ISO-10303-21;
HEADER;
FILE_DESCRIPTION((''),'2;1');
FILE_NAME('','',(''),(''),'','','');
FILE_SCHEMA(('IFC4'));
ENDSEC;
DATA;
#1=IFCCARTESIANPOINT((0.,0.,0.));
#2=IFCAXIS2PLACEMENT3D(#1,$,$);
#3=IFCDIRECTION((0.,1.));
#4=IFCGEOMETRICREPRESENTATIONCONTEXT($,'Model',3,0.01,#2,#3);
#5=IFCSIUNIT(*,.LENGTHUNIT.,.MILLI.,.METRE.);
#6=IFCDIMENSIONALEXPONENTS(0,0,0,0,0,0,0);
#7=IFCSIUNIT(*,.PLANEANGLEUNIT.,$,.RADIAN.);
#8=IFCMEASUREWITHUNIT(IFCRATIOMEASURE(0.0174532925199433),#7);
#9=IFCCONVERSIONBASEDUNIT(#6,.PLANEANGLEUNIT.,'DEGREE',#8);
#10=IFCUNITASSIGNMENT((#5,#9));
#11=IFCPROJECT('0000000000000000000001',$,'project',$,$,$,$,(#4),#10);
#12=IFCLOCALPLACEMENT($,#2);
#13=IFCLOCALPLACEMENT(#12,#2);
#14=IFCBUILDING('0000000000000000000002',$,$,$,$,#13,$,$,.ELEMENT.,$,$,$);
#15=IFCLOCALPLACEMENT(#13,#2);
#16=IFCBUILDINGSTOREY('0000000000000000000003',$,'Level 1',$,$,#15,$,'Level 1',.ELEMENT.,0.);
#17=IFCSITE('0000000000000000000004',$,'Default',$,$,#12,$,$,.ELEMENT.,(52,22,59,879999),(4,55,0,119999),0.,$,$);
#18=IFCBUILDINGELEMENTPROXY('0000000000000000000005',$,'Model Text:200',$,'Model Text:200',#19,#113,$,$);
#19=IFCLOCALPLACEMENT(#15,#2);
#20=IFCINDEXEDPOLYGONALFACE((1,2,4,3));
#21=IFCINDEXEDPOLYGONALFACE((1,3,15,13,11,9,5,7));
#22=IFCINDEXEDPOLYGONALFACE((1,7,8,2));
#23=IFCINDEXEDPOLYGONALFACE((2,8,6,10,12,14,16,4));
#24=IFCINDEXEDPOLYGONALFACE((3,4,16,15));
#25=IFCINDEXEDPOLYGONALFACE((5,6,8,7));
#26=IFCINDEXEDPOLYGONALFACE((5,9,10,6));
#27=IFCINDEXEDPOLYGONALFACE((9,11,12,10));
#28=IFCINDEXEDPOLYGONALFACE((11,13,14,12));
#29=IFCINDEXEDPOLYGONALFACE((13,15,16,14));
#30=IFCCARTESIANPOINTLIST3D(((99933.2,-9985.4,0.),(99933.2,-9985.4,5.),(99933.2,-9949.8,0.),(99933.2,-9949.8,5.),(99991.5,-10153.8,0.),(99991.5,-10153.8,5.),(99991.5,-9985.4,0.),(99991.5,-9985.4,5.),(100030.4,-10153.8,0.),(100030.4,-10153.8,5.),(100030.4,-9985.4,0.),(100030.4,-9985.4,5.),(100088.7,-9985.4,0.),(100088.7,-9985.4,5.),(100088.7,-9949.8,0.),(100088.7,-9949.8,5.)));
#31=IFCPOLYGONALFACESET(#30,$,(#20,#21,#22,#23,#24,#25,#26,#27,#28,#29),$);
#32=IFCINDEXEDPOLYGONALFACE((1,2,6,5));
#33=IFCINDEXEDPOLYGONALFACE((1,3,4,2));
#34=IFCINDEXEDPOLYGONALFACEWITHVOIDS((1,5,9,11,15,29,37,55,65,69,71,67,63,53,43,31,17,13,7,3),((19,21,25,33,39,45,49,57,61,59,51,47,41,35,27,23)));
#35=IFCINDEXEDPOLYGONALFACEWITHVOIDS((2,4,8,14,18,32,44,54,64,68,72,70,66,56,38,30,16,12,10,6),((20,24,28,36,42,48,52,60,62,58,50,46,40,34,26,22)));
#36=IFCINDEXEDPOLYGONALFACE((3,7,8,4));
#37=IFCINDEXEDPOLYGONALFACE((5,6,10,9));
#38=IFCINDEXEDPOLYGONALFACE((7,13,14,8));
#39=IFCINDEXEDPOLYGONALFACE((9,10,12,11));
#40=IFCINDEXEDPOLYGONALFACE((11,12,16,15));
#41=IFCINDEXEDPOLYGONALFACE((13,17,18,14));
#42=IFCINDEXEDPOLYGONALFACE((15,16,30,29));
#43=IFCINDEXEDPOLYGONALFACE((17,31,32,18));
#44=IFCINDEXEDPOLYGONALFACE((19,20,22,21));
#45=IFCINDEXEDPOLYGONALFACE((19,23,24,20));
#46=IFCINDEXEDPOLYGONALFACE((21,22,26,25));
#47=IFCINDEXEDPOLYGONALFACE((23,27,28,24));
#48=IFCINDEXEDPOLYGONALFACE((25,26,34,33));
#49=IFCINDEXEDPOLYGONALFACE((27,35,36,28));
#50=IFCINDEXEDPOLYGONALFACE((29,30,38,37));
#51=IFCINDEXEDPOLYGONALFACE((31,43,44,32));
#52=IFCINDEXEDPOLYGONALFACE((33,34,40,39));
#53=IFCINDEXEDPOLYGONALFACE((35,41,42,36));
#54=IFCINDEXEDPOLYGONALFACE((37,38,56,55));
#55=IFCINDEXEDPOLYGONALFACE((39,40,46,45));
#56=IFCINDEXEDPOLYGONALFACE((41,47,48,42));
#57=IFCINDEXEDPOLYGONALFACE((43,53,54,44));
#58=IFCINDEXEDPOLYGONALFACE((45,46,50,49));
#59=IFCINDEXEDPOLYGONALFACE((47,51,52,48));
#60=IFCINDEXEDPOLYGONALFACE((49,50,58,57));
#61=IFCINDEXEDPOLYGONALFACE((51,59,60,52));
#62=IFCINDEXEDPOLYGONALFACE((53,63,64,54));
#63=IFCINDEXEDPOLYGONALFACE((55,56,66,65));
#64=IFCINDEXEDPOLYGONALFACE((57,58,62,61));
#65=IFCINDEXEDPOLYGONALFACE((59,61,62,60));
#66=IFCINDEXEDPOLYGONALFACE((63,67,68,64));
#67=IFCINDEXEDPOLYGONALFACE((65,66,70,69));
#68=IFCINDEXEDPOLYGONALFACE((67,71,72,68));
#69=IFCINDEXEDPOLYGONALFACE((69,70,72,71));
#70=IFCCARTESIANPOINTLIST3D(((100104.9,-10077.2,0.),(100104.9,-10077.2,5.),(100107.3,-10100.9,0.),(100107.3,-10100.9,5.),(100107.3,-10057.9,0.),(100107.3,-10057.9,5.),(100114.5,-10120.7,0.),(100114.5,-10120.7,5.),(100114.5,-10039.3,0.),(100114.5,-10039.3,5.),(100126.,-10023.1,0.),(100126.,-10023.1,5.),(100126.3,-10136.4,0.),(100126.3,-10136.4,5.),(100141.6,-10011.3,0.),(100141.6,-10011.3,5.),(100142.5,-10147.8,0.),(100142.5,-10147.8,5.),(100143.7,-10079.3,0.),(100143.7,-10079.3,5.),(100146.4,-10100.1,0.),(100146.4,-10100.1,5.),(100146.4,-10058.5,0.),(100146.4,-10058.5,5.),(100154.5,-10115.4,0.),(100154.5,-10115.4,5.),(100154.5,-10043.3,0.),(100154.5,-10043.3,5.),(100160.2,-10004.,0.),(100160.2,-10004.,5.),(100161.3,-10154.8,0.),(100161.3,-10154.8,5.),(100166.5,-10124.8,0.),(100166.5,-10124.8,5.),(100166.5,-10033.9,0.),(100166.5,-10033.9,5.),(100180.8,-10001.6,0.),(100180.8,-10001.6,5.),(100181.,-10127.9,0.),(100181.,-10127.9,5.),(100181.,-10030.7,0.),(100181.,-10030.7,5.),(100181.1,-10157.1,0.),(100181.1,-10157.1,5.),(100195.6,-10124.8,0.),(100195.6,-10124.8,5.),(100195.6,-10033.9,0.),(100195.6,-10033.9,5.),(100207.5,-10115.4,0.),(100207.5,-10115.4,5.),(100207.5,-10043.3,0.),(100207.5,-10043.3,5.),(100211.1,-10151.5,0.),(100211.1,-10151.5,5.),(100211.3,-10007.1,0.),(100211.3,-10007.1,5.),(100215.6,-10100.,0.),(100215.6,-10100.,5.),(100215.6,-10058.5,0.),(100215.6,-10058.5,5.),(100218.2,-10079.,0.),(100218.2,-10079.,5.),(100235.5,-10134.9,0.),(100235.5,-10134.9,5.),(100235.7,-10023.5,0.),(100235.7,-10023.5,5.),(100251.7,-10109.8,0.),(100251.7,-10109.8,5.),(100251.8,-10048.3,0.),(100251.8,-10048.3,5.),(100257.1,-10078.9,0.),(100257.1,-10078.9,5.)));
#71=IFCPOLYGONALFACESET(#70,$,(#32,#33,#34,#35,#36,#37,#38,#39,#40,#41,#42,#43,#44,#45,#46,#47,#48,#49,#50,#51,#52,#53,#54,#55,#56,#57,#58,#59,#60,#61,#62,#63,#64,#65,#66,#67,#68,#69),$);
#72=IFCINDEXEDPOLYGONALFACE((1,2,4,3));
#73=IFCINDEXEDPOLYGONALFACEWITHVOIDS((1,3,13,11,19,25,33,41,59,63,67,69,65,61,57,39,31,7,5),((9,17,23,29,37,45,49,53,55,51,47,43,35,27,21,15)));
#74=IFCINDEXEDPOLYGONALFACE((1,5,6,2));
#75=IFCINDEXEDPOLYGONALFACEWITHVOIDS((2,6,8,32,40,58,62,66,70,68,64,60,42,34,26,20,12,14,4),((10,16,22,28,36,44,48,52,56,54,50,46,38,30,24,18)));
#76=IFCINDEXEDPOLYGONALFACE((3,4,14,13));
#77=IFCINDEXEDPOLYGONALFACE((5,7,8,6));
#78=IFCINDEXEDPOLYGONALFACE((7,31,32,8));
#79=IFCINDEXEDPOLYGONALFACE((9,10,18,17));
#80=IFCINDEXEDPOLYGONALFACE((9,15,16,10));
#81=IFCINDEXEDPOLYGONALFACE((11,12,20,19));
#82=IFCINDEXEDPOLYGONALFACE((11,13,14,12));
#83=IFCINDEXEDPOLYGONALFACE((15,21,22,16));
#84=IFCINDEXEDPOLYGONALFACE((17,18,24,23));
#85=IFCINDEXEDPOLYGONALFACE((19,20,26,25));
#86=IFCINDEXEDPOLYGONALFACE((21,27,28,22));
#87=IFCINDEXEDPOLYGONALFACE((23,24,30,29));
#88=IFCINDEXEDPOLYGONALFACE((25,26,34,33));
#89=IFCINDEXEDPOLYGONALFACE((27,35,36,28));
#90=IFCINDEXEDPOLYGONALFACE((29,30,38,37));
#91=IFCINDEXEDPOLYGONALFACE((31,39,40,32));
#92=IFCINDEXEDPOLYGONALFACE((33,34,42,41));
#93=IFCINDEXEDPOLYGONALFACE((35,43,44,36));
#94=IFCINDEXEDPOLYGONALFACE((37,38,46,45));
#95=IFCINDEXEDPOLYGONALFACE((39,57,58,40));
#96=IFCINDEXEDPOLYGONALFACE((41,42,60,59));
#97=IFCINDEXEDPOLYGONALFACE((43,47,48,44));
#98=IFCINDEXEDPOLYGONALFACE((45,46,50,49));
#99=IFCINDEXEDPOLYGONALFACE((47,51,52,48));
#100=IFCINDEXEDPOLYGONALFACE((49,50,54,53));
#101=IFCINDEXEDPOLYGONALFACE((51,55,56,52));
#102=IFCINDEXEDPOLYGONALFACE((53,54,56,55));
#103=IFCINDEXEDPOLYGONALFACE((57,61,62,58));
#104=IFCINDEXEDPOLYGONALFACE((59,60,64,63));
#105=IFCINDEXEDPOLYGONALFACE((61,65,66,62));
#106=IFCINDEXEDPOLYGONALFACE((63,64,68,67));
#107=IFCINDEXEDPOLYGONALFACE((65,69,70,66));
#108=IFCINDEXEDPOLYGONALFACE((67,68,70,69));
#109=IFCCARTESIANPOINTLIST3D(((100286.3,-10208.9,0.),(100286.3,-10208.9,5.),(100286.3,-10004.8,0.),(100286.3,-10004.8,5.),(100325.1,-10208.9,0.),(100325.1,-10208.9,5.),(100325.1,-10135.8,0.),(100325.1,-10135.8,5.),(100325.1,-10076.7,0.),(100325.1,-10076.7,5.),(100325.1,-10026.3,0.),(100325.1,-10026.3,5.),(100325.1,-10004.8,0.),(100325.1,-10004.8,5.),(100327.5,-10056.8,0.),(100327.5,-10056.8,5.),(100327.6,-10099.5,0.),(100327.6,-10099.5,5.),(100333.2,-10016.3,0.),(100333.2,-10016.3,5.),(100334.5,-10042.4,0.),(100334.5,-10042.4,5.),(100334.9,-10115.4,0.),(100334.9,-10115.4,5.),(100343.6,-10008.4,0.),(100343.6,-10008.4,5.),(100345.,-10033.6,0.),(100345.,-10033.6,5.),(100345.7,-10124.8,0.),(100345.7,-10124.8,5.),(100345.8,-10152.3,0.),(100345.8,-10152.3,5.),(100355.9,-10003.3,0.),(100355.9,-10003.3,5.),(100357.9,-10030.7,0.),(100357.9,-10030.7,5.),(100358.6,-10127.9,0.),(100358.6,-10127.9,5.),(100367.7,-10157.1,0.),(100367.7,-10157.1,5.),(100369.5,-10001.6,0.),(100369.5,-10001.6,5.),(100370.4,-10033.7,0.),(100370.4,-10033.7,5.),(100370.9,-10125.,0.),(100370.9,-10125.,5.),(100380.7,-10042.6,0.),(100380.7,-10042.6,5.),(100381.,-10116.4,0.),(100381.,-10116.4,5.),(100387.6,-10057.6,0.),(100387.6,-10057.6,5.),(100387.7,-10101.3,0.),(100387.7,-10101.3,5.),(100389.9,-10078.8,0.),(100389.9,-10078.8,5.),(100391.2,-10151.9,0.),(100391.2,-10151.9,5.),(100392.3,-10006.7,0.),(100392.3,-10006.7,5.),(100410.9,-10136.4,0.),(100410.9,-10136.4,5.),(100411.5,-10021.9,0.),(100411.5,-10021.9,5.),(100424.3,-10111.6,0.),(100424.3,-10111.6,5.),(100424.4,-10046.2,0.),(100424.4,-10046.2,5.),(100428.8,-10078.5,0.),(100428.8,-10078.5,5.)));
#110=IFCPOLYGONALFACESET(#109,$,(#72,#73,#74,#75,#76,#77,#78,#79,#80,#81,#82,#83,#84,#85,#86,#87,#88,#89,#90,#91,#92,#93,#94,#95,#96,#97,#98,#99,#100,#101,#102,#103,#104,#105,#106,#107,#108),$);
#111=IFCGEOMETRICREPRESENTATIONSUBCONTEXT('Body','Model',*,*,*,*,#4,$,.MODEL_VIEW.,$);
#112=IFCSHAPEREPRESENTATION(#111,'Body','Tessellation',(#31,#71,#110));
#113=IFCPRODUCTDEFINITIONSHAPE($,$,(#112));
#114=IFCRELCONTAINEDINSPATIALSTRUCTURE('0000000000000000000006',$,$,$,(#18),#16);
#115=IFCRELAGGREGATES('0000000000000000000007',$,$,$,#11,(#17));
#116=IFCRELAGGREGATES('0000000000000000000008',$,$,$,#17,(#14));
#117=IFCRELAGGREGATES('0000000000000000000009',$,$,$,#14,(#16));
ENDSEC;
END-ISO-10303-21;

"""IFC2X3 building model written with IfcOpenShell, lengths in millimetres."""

from ifc_helpers import new_model, entity, si_unit, converted_unit, direction, frame, origin, place, context, subcontext, project, spatial, polyline, outline, extrude, element, save


model = new_model("IFC2X3")

# Units and contexts
model_context = context("Model", 3, precision=0.01, world=origin(), true_north=direction((0.0, 1.0)))
body_context = subcontext(model_context, "Body", "Model", "MODEL_VIEW")
ifc_project = project(units=[si_unit("LENGTHUNIT", "METRE", prefix="MILLI"), converted_unit("PLANEANGLEUNIT", "DEGREE", entity("IfcRatioMeasure", 0.0174532925199433), si_unit("PLANEANGLEUNIT", "RADIAN"), dimensions=[0, 0, 0, 0, 0, 0, 0])], contexts=[model_context])

# Site, building, storey
site_placement = place(None, origin())
site = spatial("IfcSite", under=ifc_project, at=site_placement, Name="Default", CompositionType="ELEMENT", RefLatitude=(52, 22, 59, 879999), RefLongitude=(4, 55, 0, 119999), RefElevation=0.0)
building_placement = place(site_placement, origin())
building = spatial("IfcBuilding", under=site, at=building_placement, CompositionType="ELEMENT")
storey_placement = place(building_placement, origin())
storey = spatial("IfcBuildingStorey", under=building, at=storey_placement, Name="Level 1", LongName="Level 1", CompositionType="ELEMENT", Elevation=0.0)

# Building element proxy
proxy_1_placement = place(building_placement, origin())
element("IfcBuildingElementProxy", 1, at=proxy_1_placement, inside=storey, Name="Model Text:200", ObjectType="Model Text:200", context=body_context, shape_type="SweptSolid", body=[
    extrude(outline(polyline([(-19.4, -135.2), (19.4, -135.2), (19.4, 33.2), (77.7, 33.2), (77.7, 68.8), (-77.7, 68.8), (-77.7, 33.2), (-19.4, 33.2), (-19.4, -135.2)])), frame((100010.9, -10018.6, 0.0)), (0.0, 0.0, 1.0), 5.0),
    extrude(outline(polyline([(-8.8, -65.7), (15.1, -65.7), (35.5, -60.5), (52.3, -50.4), (65.3, -35.4), (74.1, -17.3), (78.4, 2.1), (75.9, 32.5), (61.8, 58.5), (38.4, 77.1), (8.3, 85.6), (-22.7, 83.3), (-49.0, 69.9), (-67.8, 47.3), (-76.3, 17.5), (-76.0, -3.3), (-70.7, -22.5), (-60.5, -39.2), (-45.5, -52.3), (-27.7, -61.4), (-8.8, -65.7)]), holes=[polyline([(-2.7, -27.2), (-23.1, -22.5), (-37.5, -12.9), (-45.7, 0.0), (-47.3, 14.8), (-42.7, 28.9), (-32.2, 39.9), (-16.3, 46.3), (4.5, 46.9), (25.1, 42.1), (39.6, 32.6), (47.7, 19.7), (49.4, 5.0), (44.8, -9.2), (34.2, -20.2), (18.2, -26.7), (-2.7, -27.2)])]), frame((100171.1, -10079.3, 0.0), z_axis=(0.0, 0.0, 1.0), x_axis=(0.100608, -0.994926, 0.0)), (0.0, 0.0, 1.0), 5.0),
    extrude(outline(polyline([(-73.1, -75.4), (130.9, -75.4), (130.9, -36.6), (57.8, -36.6), (74.3, -15.9), (79.1, 6.0), (73.9, 29.5), (58.4, 49.2), (33.6, 62.6), (0.5, 67.1), (-31.8, 62.8), (-56.1, 49.8), (-71.3, 30.7), (-76.4, 7.8), (-74.7, -5.8), (-69.6, -18.1), (-61.7, -28.5), (-51.7, -36.6), (-73.1, -36.6), (-73.1, -75.4)]), holes=[polyline([(-1.2, -36.6), (-21.2, -34.2), (-35.6, -27.2), (-44.3, -16.7), (-47.2, -3.8), (-44.3, 8.7), (-35.4, 19.0), (-20.4, 25.9), (0.8, 28.2), (23.3, 26.0), (38.5, 19.3), (47.1, 9.2), (49.9, -3.1), (46.8, -16.0), (37.4, -26.8), (21.5, -34.1), (-1.2, -36.6)])]), frame((100361.7, -10078.0, 0.0), z_axis=(0.0, 0.0, 1.0), x_axis=(0.0, -1.0, 0.0)), (0.0, 0.0, 1.0), 5.0),
])

save(model, "model.ifc")
